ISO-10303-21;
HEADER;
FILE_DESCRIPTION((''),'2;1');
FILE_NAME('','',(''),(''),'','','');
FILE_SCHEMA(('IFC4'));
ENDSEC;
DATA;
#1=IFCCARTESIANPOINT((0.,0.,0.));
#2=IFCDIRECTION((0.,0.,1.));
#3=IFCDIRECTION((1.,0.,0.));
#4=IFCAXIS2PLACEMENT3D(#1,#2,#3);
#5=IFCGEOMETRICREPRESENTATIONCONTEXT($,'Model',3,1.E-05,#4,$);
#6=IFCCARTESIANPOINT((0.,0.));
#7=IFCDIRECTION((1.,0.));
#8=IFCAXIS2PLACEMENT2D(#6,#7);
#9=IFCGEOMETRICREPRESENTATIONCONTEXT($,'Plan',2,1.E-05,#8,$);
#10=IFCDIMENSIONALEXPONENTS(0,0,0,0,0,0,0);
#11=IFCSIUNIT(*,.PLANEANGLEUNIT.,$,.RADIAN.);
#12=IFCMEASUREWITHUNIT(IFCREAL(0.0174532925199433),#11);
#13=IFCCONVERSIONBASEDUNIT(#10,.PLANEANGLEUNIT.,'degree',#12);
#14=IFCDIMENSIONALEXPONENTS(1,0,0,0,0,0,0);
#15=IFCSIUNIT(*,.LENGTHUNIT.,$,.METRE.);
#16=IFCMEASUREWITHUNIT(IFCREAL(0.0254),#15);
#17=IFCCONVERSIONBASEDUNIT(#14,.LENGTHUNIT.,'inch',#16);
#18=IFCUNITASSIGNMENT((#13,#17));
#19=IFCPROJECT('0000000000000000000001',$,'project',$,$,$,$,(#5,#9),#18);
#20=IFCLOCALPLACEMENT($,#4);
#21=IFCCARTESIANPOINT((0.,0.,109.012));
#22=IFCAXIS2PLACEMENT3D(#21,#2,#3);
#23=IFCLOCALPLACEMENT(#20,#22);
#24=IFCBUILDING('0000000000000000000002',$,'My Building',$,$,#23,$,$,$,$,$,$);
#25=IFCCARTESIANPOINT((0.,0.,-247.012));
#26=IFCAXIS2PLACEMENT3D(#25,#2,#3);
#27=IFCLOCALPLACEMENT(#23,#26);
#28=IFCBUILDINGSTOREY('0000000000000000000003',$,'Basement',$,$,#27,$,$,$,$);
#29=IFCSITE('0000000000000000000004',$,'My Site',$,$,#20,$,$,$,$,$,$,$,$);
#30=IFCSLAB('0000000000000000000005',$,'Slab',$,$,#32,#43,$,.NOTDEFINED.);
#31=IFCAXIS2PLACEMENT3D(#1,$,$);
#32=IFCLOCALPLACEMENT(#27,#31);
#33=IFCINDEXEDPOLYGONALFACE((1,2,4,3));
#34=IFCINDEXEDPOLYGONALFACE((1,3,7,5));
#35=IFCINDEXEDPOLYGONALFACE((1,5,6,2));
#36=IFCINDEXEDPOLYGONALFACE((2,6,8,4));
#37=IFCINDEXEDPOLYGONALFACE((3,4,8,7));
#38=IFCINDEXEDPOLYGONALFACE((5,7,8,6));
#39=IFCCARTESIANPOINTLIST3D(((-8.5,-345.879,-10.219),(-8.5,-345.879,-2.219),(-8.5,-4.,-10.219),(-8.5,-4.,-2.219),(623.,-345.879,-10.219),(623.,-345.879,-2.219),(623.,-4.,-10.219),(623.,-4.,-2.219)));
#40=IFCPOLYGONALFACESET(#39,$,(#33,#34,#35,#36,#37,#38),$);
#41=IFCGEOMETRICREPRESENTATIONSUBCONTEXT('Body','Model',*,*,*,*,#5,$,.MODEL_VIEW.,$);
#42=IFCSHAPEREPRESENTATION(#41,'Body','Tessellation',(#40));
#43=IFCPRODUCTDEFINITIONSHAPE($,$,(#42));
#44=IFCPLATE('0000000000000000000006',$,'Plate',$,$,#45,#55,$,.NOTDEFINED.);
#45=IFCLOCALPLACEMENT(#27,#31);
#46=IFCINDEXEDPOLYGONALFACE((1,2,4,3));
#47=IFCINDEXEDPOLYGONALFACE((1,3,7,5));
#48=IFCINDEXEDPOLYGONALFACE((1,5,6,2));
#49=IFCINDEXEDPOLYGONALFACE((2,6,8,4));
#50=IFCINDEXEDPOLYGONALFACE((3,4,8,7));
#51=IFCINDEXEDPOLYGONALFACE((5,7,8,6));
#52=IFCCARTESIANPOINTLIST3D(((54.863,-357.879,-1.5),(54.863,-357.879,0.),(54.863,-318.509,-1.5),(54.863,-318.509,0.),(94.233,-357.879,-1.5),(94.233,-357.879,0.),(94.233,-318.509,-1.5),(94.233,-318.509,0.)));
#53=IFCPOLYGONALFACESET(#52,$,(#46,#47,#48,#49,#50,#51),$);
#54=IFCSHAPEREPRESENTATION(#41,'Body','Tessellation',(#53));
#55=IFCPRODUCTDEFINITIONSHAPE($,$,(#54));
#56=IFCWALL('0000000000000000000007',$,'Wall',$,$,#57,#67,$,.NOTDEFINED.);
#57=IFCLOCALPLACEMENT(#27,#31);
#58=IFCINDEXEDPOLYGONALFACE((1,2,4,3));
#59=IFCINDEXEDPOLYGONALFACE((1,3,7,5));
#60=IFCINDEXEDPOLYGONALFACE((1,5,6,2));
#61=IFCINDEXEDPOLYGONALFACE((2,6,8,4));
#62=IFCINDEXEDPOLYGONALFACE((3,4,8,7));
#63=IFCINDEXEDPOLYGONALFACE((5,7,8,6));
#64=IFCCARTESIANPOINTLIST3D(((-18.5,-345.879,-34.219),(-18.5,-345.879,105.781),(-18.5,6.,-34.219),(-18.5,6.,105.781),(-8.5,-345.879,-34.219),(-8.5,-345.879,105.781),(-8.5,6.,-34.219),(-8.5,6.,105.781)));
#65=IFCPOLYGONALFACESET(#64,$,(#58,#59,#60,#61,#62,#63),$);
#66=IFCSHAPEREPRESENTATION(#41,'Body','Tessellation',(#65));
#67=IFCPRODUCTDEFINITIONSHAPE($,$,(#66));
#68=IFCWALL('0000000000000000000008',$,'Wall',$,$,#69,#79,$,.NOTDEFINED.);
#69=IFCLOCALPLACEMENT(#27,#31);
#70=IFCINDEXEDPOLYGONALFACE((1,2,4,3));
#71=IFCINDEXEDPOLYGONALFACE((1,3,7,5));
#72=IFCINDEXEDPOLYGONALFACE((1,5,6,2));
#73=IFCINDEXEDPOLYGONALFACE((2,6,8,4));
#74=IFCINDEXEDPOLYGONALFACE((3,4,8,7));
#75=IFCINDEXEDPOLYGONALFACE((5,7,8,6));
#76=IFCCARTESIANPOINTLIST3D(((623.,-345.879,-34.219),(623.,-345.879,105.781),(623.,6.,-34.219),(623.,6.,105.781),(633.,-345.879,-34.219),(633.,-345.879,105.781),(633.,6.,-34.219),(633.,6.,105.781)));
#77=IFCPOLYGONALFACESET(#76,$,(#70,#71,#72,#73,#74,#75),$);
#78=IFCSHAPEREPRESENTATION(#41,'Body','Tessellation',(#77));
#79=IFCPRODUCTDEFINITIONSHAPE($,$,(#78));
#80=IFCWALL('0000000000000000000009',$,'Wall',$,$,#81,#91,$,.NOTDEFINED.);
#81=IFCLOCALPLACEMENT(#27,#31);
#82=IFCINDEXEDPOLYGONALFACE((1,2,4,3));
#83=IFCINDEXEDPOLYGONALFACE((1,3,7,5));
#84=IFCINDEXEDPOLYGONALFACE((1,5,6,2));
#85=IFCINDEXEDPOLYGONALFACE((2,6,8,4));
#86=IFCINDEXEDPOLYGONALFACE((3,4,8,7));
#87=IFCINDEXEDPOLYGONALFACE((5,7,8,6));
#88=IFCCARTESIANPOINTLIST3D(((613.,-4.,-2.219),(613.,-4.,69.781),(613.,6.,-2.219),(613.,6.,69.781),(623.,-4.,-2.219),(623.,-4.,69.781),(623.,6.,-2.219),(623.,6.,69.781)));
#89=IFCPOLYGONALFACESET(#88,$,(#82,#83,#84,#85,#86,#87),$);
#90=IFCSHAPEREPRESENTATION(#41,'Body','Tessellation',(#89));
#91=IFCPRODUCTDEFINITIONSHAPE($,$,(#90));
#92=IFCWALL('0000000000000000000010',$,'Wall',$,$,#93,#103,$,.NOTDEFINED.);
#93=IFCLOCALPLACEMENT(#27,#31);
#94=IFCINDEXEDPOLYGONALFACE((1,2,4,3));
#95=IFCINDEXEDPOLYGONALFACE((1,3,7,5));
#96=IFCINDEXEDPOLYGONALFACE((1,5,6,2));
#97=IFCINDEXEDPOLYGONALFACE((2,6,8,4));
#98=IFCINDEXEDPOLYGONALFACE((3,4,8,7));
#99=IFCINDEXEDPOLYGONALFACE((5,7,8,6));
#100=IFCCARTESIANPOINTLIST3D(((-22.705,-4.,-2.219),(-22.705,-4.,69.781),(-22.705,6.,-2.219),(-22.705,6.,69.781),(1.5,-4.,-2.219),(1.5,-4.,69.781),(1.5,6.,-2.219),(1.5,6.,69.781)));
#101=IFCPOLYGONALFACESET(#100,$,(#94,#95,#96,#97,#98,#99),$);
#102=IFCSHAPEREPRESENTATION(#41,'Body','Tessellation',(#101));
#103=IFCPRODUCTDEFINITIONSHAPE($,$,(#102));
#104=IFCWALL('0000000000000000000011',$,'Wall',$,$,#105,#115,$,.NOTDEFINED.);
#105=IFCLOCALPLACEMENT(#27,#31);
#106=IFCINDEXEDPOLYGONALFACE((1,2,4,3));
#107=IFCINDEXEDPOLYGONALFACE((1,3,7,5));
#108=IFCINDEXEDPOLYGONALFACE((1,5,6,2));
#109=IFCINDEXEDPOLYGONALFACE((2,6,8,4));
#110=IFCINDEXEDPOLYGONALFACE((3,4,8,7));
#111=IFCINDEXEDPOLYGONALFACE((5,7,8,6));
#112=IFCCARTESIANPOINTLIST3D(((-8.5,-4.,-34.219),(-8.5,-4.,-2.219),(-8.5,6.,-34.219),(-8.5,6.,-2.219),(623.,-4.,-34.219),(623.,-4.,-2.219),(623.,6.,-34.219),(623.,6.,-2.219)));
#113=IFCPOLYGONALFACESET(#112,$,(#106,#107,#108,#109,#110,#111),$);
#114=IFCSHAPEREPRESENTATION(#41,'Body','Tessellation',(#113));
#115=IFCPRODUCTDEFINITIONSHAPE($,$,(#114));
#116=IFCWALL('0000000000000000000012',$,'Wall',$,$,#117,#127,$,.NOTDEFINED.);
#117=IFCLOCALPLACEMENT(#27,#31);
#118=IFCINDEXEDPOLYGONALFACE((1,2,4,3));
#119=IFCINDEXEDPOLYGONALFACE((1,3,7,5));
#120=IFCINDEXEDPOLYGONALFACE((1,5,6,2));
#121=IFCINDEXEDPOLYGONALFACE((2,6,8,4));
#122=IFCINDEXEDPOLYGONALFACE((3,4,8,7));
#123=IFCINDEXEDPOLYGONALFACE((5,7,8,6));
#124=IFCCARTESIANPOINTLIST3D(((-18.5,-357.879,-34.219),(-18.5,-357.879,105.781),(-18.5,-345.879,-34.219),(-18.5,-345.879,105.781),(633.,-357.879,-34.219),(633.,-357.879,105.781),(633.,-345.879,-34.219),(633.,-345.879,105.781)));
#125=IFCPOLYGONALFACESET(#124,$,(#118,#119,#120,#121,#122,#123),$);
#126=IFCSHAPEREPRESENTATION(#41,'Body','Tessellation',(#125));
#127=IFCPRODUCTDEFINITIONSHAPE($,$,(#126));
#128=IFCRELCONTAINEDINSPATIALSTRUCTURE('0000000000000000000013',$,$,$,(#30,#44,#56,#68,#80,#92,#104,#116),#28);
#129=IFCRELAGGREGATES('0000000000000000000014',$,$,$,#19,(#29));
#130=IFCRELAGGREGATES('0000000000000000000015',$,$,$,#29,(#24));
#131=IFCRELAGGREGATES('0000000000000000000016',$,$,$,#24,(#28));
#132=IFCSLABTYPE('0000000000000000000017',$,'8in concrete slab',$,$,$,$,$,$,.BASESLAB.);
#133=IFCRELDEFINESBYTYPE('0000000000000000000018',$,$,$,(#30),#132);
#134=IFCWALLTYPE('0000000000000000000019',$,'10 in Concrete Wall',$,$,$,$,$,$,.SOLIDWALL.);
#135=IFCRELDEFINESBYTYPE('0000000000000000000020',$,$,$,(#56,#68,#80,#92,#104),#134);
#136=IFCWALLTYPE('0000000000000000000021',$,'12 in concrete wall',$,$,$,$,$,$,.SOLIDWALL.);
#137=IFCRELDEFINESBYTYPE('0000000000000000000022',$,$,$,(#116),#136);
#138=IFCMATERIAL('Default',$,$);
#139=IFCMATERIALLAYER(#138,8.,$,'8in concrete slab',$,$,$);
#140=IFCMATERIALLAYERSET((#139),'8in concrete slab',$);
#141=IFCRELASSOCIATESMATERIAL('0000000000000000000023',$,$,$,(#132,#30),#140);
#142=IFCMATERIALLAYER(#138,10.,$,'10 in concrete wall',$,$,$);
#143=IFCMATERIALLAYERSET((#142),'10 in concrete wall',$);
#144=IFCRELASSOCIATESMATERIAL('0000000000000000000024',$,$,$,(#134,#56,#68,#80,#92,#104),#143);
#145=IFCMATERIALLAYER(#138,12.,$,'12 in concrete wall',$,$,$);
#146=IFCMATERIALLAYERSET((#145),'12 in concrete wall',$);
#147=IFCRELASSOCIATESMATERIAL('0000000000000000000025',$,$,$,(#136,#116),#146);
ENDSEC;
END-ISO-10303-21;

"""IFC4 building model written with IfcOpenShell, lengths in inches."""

from ifc_helpers import new_model, entity, si_unit, converted_unit, frame, origin_with_axes, origin_2d_with_axis, place, context, subcontext, project, spatial, line, indexed_curve, outline, extrude, material, layer, layer_set, layer_usage, type_object, element, save


model = new_model("IFC4")

# Units and contexts
model_context = context("Model", 3, precision=1e-05, world=origin_with_axes())
plan_context = context("Plan", 2, precision=1e-05, world=origin_2d_with_axis())
body_context = subcontext(model_context, "Body", "Model", "MODEL_VIEW")
ifc_project = project(units=[converted_unit("PLANEANGLEUNIT", "degree", entity("IfcReal", 0.0174532925199433), si_unit("PLANEANGLEUNIT", "RADIAN"), dimensions=[0, 0, 0, 0, 0, 0, 0]), converted_unit("LENGTHUNIT", "inch", entity("IfcReal", 0.0254), si_unit("LENGTHUNIT", "METRE"), dimensions=[1, 0, 0, 0, 0, 0, 0])], contexts=[model_context, plan_context])

# Site, building, storey
site_placement = place(None, origin_with_axes())
site = spatial("IfcSite", under=ifc_project, at=site_placement, Name="My Site")
building_placement = place(site_placement, frame((0.0, 0.0, 109.012), z_axis=(0.0, 0.0, 1.0), x_axis=(1.0, 0.0, 0.0)))
building = spatial("IfcBuilding", under=site, at=building_placement, Name="My Building")
storey_placement = place(building_placement, frame((0.0, 0.0, -247.012), z_axis=(0.0, 0.0, 1.0), x_axis=(1.0, 0.0, 0.0)))
storey = spatial("IfcBuildingStorey", under=building, at=storey_placement, Name="Basement")

# Shared definitions
ifc_material_1 = material(Name="Default")

# Slab
ifc_layer_1 = layer(ifc_material_1, 8.0, Name="8in concrete slab")
ifc_layer_set_1 = layer_set([ifc_layer_1], Name="8in concrete slab")
ifc_layer_usage_1 = layer_usage(ifc_layer_set_1, "AXIS3", "POSITIVE", 0.0)
slab_type = type_object("IfcSlabType", Name="8in concrete slab", PredefinedType="BASESLAB", material=ifc_layer_set_1)
slab_placement = place(storey_placement, frame((-8.5, -345.879, -10.219), z_axis=(0.0, 0.0, 1.0), x_axis=(1.0, 0.0, 0.0)))
element("IfcSlab", 1, at=slab_placement, inside=storey, type_object=slab_type, material=ifc_layer_usage_1, Name="Slab", PredefinedType="NOTDEFINED", context=body_context, shape_type="SweptSolid", body=[
    extrude(outline(indexed_curve([(0.0, 0.0), (631.5, 0.0), (631.5, 341.879), (0.0, 341.879)], segments=[line(3, 2), line(2, 1), line(1, 4), line(4, 3)], self_intersect=False)), None, (0.0, 0.0, 1.0), 8.0),
])

# Plate
plate_placement = place(storey_placement, frame((54.863, -357.879, -1.5), z_axis=(0.0, 0.0, 1.0), x_axis=(1.0, 0.0, 0.0)))
element("IfcPlate", 2, at=plate_placement, inside=storey, Name="Plate", PredefinedType="NOTDEFINED", context=body_context, shape_type="SweptSolid", body=[
    extrude(outline(indexed_curve([(0.0, 0.0), (39.37, 0.0), (39.37, 39.37), (0.0, 39.37), (0.0, 0.0)])), None, (0.0, 0.0, 1.0), 1.5),
])

# Walls
ifc_layer_2 = layer(ifc_material_1, 10.0, Name="10 in concrete wall")
ifc_layer_set_2 = layer_set([ifc_layer_2], Name="10 in concrete wall")
ifc_layer_usage_2 = layer_usage(ifc_layer_set_2, "AXIS2", "POSITIVE", 0.0)
wall_type_1 = type_object("IfcWallType", Name="10 in Concrete Wall", PredefinedType="SOLIDWALL", material=ifc_layer_set_2)
wall_1_placement = place(storey_placement, frame((-18.5, 6.0, -34.219), z_axis=(0.0, 0.0, 1.0), x_axis=(0.0, -1.0, 0.0)))
element("IfcWall", 3, at=wall_1_placement, inside=storey, type_object=wall_type_1, material=ifc_layer_usage_2, Name="Wall", PredefinedType="NOTDEFINED", context=body_context, shape_type="SweptSolid", body=[
    extrude(outline(indexed_curve([(0.0, 0.0), (0.0, 10.0), (351.879, 10.0), (351.879, 0.0), (0.0, 0.0)], self_intersect=False)), origin_with_axes(), (0.0, 0.0, 1.0), 140.0),
])
ifc_layer_usage_3 = layer_usage(ifc_layer_set_2, "AXIS2", "POSITIVE", 0.0)
wall_2_placement = place(storey_placement, frame((623.0, 6.0, -34.219), z_axis=(0.0, 0.0, 1.0), x_axis=(0.0, -1.0, 0.0)))
element("IfcWall", 4, at=wall_2_placement, inside=storey, type_object=wall_type_1, material=ifc_layer_usage_3, Name="Wall", PredefinedType="NOTDEFINED", context=body_context, shape_type="SweptSolid", body=[
    extrude(outline(indexed_curve([(0.0, 0.0), (0.0, 10.0), (351.879, 10.0), (351.879, 0.0), (0.0, 0.0)], self_intersect=False)), origin_with_axes(), (0.0, 0.0, 1.0), 140.0),
])
ifc_layer_usage_4 = layer_usage(ifc_layer_set_2, "AXIS2", "POSITIVE", 0.0)
wall_3_placement = place(storey_placement, frame((623.0, 6.0, -2.219), z_axis=(0.0, 0.0, 1.0), x_axis=(-1.0, 0.0, 0.0)))
element("IfcWall", 5, at=wall_3_placement, inside=storey, type_object=wall_type_1, material=ifc_layer_usage_4, Name="Wall", PredefinedType="NOTDEFINED", context=body_context, shape_type="SweptSolid", body=[
    extrude(outline(indexed_curve([(0.0, 0.0), (0.0, 10.0), (10.0, 10.0), (10.0, 0.0), (0.0, 0.0)], self_intersect=False)), origin_with_axes(), (0.0, 0.0, 1.0), 72.0),
])
ifc_layer_usage_5 = layer_usage(ifc_layer_set_2, "AXIS2", "POSITIVE", 0.0)
wall_4_placement = place(storey_placement, frame((1.5, 6.0, -2.219), z_axis=(0.0, 0.0, 1.0), x_axis=(-1.0, 0.0, 0.0)))
element("IfcWall", 6, at=wall_4_placement, inside=storey, type_object=wall_type_1, material=ifc_layer_usage_5, Name="Wall", PredefinedType="NOTDEFINED", context=body_context, shape_type="SweptSolid", body=[
    extrude(outline(indexed_curve([(0.0, 0.0), (0.0, 10.0), (24.204, 10.0), (24.204, 0.0), (0.0, 0.0)], self_intersect=False)), origin_with_axes(), (0.0, 0.0, 1.0), 72.0),
])
ifc_layer_usage_6 = layer_usage(ifc_layer_set_2, "AXIS2", "POSITIVE", 0.0)
wall_5_placement = place(storey_placement, frame((623.0, 6.0, -34.219), z_axis=(0.0, 0.0, 1.0), x_axis=(-1.0, 0.0, 0.0)))
element("IfcWall", 7, at=wall_5_placement, inside=storey, type_object=wall_type_1, material=ifc_layer_usage_6, Name="Wall", PredefinedType="NOTDEFINED", context=body_context, shape_type="SweptSolid", body=[
    extrude(outline(indexed_curve([(0.0, 0.0), (0.0, 10.0), (631.5, 10.0), (631.5, 0.0), (0.0, 0.0)], self_intersect=False)), origin_with_axes(), (0.0, 0.0, 1.0), 32.0),
])
ifc_layer_3 = layer(ifc_material_1, 12.0, Name="12 in concrete wall")
ifc_layer_set_3 = layer_set([ifc_layer_3], Name="12 in concrete wall")
ifc_layer_usage_7 = layer_usage(ifc_layer_set_3, "AXIS2", "POSITIVE", 0.0)
wall_type_2 = type_object("IfcWallType", Name="12 in concrete wall", PredefinedType="SOLIDWALL", material=ifc_layer_set_3)
wall_6_placement = place(storey_placement, frame((-18.5, -357.879, -34.219), z_axis=(0.0, 0.0, 1.0), x_axis=(1.0, 0.0, 0.0)))
element("IfcWall", 8, at=wall_6_placement, inside=storey, type_object=wall_type_2, material=ifc_layer_usage_7, Name="Wall", PredefinedType="NOTDEFINED", context=body_context, shape_type="SweptSolid", body=[
    extrude(outline(indexed_curve([(0.0, 0.0), (0.0, 12.0), (651.5, 12.0), (651.5, 0.0), (0.0, 0.0)], self_intersect=False)), origin_with_axes(), (0.0, 0.0, 1.0), 140.0),
])

save(model, "model.ifc")
